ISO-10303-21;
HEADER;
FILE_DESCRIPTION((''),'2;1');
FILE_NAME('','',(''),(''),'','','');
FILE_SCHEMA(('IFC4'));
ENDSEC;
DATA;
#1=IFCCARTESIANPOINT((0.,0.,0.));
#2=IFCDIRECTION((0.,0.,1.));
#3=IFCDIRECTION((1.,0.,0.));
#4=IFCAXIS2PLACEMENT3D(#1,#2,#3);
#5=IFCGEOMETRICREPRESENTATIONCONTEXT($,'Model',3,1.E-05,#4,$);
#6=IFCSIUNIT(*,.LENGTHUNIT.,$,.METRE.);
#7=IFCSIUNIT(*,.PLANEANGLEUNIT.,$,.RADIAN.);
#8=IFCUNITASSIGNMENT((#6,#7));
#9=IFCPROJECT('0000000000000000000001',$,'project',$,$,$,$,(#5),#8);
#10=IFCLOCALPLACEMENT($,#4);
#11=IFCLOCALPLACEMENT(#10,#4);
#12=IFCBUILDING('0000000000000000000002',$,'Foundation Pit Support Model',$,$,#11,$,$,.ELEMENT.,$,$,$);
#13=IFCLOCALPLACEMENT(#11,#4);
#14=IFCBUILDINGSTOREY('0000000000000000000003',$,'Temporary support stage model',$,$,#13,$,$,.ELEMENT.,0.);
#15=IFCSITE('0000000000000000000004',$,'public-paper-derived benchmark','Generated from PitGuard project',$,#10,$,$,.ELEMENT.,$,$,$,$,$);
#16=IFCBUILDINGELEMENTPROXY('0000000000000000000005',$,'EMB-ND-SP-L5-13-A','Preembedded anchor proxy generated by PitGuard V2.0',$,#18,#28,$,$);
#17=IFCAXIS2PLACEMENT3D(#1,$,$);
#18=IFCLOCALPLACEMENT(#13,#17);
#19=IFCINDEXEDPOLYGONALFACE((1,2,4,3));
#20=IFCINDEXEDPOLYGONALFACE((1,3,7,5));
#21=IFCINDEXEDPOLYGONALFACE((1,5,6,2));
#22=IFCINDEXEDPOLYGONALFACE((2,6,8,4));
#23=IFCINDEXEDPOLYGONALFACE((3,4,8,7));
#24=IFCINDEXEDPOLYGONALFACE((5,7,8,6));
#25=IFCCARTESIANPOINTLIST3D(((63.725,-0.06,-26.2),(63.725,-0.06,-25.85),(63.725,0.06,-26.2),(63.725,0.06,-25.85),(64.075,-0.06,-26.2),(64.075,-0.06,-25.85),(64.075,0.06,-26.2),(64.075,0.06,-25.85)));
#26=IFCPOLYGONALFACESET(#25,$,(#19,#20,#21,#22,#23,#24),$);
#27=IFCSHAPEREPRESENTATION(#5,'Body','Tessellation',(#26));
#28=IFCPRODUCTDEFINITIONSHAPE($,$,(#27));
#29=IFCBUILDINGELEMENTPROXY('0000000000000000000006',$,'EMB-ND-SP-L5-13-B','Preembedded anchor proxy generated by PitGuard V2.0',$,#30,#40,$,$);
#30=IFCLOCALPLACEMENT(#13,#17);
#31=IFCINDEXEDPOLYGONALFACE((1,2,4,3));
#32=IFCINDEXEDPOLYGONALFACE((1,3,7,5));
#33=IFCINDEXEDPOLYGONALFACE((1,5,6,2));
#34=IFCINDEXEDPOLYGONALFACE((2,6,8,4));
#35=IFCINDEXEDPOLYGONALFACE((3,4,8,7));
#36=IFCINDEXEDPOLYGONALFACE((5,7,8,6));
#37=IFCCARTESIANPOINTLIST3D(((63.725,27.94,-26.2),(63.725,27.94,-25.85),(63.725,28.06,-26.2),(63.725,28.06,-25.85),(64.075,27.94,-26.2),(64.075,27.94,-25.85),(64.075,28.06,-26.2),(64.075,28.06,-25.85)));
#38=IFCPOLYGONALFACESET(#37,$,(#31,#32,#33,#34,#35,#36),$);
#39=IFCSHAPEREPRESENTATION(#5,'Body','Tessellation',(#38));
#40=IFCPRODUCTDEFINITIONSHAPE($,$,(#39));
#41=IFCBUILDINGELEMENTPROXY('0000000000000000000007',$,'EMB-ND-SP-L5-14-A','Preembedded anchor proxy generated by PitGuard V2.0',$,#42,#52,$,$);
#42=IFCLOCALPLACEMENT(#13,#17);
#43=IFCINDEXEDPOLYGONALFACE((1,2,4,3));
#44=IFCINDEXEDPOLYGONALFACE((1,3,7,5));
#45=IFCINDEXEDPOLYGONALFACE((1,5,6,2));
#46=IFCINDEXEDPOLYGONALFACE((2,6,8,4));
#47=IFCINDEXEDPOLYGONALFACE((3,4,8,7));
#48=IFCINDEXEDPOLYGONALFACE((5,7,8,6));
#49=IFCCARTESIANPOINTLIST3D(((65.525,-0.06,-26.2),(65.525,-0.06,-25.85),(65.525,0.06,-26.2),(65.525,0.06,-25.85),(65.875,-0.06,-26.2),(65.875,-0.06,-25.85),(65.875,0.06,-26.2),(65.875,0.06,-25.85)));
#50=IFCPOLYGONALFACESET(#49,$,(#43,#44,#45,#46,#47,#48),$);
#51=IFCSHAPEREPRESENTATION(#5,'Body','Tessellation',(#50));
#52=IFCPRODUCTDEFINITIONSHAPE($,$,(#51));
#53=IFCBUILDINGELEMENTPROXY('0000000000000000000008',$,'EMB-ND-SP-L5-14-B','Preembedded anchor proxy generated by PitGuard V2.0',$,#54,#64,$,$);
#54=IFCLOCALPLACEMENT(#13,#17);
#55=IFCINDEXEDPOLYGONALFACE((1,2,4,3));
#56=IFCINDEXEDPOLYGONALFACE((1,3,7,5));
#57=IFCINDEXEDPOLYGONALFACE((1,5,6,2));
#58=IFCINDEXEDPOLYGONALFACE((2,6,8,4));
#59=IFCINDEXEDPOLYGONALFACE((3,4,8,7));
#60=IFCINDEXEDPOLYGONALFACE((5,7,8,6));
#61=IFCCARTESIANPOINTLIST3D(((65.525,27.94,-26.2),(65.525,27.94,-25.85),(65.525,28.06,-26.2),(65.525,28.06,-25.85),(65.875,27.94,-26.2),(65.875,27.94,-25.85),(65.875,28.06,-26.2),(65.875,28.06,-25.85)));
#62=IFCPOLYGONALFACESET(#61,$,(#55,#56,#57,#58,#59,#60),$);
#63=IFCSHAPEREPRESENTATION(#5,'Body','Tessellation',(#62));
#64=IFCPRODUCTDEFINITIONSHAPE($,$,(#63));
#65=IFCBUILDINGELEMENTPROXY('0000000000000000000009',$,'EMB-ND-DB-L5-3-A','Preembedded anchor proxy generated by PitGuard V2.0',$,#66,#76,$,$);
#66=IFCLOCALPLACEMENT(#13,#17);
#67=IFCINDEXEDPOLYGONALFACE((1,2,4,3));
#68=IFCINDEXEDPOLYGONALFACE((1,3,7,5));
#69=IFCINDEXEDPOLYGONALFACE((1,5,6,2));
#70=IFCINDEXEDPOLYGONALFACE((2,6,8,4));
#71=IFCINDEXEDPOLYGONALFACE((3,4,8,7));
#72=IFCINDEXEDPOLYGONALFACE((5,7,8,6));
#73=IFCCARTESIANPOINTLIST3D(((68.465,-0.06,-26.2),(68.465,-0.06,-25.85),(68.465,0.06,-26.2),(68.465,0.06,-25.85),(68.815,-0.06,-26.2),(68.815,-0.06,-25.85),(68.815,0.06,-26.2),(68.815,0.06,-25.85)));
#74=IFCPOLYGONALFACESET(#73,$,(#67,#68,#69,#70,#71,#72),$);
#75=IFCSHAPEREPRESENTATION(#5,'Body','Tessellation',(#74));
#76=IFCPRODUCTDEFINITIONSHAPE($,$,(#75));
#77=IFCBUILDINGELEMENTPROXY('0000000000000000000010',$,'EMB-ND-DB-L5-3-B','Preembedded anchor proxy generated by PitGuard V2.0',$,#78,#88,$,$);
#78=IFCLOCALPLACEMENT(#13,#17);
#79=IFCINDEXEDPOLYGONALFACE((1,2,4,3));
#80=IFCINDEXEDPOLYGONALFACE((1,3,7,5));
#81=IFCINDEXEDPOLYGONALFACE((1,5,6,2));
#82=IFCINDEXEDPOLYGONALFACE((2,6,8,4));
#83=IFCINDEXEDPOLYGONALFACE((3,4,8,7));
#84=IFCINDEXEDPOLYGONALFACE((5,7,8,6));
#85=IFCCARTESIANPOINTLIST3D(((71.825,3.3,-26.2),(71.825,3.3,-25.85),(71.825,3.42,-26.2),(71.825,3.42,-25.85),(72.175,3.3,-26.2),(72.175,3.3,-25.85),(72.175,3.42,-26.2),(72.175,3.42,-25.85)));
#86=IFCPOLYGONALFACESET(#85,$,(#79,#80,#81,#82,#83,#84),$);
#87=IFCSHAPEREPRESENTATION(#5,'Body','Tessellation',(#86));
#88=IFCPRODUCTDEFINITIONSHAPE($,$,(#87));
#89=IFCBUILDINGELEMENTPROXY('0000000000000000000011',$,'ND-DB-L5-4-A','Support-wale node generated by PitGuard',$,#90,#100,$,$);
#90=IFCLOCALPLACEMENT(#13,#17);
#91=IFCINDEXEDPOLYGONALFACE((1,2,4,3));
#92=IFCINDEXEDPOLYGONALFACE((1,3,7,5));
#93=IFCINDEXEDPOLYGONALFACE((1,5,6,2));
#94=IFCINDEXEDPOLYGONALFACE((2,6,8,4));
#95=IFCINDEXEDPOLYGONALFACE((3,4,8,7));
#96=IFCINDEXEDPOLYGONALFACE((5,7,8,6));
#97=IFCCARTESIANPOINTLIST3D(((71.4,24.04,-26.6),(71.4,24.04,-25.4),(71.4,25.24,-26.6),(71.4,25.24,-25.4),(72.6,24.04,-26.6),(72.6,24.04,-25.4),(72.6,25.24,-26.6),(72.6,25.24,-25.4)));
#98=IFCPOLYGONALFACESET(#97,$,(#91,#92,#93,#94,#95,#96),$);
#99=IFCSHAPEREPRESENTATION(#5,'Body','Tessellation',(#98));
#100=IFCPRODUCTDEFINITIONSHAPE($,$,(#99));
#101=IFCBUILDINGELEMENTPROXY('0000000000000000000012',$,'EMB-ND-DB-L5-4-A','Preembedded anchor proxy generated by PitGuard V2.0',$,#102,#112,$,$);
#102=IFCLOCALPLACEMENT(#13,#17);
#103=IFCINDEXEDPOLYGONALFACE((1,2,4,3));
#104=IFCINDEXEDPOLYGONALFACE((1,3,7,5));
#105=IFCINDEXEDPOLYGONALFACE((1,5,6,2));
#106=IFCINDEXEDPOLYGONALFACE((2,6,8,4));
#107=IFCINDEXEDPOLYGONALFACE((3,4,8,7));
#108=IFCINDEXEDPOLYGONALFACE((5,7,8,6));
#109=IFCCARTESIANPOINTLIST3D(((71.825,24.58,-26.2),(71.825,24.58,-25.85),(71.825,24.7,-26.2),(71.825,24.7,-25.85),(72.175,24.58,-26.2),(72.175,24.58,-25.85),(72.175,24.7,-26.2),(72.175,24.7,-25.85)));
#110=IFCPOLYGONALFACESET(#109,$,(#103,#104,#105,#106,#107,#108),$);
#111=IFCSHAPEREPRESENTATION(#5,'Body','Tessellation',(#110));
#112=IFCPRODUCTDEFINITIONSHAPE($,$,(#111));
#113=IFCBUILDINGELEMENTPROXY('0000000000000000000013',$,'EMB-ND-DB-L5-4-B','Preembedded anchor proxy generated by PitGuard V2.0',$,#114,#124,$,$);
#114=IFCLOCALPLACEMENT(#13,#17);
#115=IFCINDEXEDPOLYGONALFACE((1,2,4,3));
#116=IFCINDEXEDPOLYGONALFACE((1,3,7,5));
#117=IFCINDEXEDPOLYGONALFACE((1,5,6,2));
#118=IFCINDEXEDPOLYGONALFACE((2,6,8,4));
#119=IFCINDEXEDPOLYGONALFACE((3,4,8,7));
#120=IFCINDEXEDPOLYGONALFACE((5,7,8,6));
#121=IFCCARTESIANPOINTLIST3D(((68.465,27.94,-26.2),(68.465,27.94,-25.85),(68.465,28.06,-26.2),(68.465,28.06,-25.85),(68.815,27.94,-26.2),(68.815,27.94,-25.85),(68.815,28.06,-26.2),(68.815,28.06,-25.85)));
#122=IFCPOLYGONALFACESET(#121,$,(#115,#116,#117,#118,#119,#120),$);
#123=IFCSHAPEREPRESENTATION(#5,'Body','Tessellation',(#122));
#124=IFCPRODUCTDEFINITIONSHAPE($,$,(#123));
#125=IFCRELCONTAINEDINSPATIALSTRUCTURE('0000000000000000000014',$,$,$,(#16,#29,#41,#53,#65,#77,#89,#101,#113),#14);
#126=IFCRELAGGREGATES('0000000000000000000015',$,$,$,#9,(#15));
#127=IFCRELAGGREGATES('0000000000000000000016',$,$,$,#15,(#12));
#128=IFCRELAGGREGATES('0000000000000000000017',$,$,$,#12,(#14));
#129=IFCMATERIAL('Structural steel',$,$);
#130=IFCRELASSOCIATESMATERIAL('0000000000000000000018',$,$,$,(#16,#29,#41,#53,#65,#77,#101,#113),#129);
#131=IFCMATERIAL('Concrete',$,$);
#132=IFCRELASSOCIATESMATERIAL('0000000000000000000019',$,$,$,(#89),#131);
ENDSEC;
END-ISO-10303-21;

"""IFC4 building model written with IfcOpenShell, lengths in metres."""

from ifc_helpers import new_model, si_unit, frame, origin_with_axes, origin_2d, place, context, project, spatial, rectangle, extrude, material, element, save


model = new_model("IFC4")

# Units and contexts
model_context = context("Model", 3, precision=1e-05, world=origin_with_axes())
ifc_project = project(units=[si_unit("LENGTHUNIT", "METRE"), si_unit("PLANEANGLEUNIT", "RADIAN")], contexts=[model_context])

# Site, building, storey
site_placement = place(None, origin_with_axes())
site = spatial("IfcSite", under=ifc_project, at=site_placement, Name="public-paper-derived benchmark", Description="Generated from PitGuard project", CompositionType="ELEMENT")
building_placement = place(site_placement, origin_with_axes())
building = spatial("IfcBuilding", under=site, at=building_placement, Name="Foundation Pit Support Model", CompositionType="ELEMENT")
storey_placement = place(building_placement, origin_with_axes())
storey = spatial("IfcBuildingStorey", under=building, at=storey_placement, Name="Temporary support stage model", CompositionType="ELEMENT", Elevation=0.0)

# Shared definitions
ifc_material_1 = material(Name="Concrete")

# Shared definitions
ifc_material_2 = material(Name="Structural steel")

# Building element proxies
for number, where, z_axis, x_axis, name in (
    (1, (63.9, 0.0, -26.2), (0.0, 0.0, 1.0), (1.0, 0.0, 0.0), "EMB-ND-SP-L5-13-A"),
    (2, (63.9, 28.0, -26.2), (0.0, 0.0, 1.0), (1.0, 0.0, 0.0), "EMB-ND-SP-L5-13-B"),
    (3, (65.7, 0.0, -26.2), (0.0, 0.0, 1.0), (1.0, 0.0, 0.0), "EMB-ND-SP-L5-14-A"),
    (4, (65.7, 28.0, -26.2), (0.0, 0.0, 1.0), (1.0, 0.0, 0.0), "EMB-ND-SP-L5-14-B"),
    (5, (68.64, 0.0, -26.2), (0.0, 0.0, 1.0), (1.0, 0.0, 0.0), "EMB-ND-DB-L5-3-A"),
    (6, (72.0, 3.36, -26.2), (0.0, 0.0, 1.0), (1.0, 0.0, 0.0), "EMB-ND-DB-L5-3-B"),
):
    element("IfcBuildingElementProxy", number, at=place(storey_placement, frame(where, z_axis=z_axis, x_axis=x_axis)), inside=storey, material=ifc_material_2, Name=name, Description="Preembedded anchor proxy generated by PitGuard V2.0", context=model_context, shape_type="SweptSolid", body=[
        extrude(rectangle(XDim=0.35, YDim=0.12, at=origin_2d()), origin_with_axes(), (0.0, 0.0, 1.0), 0.35),
    ])
proxy_placement = place(storey_placement, frame((72.0, 24.64, -26.6), z_axis=(0.0, 0.0, 1.0), x_axis=(1.0, 0.0, 0.0)))
element("IfcBuildingElementProxy", 7, at=proxy_placement, inside=storey, material=ifc_material_1, Name="ND-DB-L5-4-A", Description="Support-wale node generated by PitGuard", context=model_context, shape_type="SweptSolid", body=[
    extrude(rectangle(XDim=1.2, YDim=1.2, at=origin_2d()), origin_with_axes(), (0.0, 0.0, 1.0), 1.2),
])
for number, where, z_axis, x_axis, name in (
    (8, (72.0, 24.64, -26.2), (0.0, 0.0, 1.0), (1.0, 0.0, 0.0), "EMB-ND-DB-L5-4-A"),
    (9, (68.64, 28.0, -26.2), (0.0, 0.0, 1.0), (1.0, 0.0, 0.0), "EMB-ND-DB-L5-4-B"),
):
    element("IfcBuildingElementProxy", number, at=place(storey_placement, frame(where, z_axis=z_axis, x_axis=x_axis)), inside=storey, material=ifc_material_2, Name=name, Description="Preembedded anchor proxy generated by PitGuard V2.0", context=model_context, shape_type="SweptSolid", body=[
        extrude(rectangle(XDim=0.35, YDim=0.12, at=origin_2d()), origin_with_axes(), (0.0, 0.0, 1.0), 0.35),
    ])

save(model, "model.ifc")
